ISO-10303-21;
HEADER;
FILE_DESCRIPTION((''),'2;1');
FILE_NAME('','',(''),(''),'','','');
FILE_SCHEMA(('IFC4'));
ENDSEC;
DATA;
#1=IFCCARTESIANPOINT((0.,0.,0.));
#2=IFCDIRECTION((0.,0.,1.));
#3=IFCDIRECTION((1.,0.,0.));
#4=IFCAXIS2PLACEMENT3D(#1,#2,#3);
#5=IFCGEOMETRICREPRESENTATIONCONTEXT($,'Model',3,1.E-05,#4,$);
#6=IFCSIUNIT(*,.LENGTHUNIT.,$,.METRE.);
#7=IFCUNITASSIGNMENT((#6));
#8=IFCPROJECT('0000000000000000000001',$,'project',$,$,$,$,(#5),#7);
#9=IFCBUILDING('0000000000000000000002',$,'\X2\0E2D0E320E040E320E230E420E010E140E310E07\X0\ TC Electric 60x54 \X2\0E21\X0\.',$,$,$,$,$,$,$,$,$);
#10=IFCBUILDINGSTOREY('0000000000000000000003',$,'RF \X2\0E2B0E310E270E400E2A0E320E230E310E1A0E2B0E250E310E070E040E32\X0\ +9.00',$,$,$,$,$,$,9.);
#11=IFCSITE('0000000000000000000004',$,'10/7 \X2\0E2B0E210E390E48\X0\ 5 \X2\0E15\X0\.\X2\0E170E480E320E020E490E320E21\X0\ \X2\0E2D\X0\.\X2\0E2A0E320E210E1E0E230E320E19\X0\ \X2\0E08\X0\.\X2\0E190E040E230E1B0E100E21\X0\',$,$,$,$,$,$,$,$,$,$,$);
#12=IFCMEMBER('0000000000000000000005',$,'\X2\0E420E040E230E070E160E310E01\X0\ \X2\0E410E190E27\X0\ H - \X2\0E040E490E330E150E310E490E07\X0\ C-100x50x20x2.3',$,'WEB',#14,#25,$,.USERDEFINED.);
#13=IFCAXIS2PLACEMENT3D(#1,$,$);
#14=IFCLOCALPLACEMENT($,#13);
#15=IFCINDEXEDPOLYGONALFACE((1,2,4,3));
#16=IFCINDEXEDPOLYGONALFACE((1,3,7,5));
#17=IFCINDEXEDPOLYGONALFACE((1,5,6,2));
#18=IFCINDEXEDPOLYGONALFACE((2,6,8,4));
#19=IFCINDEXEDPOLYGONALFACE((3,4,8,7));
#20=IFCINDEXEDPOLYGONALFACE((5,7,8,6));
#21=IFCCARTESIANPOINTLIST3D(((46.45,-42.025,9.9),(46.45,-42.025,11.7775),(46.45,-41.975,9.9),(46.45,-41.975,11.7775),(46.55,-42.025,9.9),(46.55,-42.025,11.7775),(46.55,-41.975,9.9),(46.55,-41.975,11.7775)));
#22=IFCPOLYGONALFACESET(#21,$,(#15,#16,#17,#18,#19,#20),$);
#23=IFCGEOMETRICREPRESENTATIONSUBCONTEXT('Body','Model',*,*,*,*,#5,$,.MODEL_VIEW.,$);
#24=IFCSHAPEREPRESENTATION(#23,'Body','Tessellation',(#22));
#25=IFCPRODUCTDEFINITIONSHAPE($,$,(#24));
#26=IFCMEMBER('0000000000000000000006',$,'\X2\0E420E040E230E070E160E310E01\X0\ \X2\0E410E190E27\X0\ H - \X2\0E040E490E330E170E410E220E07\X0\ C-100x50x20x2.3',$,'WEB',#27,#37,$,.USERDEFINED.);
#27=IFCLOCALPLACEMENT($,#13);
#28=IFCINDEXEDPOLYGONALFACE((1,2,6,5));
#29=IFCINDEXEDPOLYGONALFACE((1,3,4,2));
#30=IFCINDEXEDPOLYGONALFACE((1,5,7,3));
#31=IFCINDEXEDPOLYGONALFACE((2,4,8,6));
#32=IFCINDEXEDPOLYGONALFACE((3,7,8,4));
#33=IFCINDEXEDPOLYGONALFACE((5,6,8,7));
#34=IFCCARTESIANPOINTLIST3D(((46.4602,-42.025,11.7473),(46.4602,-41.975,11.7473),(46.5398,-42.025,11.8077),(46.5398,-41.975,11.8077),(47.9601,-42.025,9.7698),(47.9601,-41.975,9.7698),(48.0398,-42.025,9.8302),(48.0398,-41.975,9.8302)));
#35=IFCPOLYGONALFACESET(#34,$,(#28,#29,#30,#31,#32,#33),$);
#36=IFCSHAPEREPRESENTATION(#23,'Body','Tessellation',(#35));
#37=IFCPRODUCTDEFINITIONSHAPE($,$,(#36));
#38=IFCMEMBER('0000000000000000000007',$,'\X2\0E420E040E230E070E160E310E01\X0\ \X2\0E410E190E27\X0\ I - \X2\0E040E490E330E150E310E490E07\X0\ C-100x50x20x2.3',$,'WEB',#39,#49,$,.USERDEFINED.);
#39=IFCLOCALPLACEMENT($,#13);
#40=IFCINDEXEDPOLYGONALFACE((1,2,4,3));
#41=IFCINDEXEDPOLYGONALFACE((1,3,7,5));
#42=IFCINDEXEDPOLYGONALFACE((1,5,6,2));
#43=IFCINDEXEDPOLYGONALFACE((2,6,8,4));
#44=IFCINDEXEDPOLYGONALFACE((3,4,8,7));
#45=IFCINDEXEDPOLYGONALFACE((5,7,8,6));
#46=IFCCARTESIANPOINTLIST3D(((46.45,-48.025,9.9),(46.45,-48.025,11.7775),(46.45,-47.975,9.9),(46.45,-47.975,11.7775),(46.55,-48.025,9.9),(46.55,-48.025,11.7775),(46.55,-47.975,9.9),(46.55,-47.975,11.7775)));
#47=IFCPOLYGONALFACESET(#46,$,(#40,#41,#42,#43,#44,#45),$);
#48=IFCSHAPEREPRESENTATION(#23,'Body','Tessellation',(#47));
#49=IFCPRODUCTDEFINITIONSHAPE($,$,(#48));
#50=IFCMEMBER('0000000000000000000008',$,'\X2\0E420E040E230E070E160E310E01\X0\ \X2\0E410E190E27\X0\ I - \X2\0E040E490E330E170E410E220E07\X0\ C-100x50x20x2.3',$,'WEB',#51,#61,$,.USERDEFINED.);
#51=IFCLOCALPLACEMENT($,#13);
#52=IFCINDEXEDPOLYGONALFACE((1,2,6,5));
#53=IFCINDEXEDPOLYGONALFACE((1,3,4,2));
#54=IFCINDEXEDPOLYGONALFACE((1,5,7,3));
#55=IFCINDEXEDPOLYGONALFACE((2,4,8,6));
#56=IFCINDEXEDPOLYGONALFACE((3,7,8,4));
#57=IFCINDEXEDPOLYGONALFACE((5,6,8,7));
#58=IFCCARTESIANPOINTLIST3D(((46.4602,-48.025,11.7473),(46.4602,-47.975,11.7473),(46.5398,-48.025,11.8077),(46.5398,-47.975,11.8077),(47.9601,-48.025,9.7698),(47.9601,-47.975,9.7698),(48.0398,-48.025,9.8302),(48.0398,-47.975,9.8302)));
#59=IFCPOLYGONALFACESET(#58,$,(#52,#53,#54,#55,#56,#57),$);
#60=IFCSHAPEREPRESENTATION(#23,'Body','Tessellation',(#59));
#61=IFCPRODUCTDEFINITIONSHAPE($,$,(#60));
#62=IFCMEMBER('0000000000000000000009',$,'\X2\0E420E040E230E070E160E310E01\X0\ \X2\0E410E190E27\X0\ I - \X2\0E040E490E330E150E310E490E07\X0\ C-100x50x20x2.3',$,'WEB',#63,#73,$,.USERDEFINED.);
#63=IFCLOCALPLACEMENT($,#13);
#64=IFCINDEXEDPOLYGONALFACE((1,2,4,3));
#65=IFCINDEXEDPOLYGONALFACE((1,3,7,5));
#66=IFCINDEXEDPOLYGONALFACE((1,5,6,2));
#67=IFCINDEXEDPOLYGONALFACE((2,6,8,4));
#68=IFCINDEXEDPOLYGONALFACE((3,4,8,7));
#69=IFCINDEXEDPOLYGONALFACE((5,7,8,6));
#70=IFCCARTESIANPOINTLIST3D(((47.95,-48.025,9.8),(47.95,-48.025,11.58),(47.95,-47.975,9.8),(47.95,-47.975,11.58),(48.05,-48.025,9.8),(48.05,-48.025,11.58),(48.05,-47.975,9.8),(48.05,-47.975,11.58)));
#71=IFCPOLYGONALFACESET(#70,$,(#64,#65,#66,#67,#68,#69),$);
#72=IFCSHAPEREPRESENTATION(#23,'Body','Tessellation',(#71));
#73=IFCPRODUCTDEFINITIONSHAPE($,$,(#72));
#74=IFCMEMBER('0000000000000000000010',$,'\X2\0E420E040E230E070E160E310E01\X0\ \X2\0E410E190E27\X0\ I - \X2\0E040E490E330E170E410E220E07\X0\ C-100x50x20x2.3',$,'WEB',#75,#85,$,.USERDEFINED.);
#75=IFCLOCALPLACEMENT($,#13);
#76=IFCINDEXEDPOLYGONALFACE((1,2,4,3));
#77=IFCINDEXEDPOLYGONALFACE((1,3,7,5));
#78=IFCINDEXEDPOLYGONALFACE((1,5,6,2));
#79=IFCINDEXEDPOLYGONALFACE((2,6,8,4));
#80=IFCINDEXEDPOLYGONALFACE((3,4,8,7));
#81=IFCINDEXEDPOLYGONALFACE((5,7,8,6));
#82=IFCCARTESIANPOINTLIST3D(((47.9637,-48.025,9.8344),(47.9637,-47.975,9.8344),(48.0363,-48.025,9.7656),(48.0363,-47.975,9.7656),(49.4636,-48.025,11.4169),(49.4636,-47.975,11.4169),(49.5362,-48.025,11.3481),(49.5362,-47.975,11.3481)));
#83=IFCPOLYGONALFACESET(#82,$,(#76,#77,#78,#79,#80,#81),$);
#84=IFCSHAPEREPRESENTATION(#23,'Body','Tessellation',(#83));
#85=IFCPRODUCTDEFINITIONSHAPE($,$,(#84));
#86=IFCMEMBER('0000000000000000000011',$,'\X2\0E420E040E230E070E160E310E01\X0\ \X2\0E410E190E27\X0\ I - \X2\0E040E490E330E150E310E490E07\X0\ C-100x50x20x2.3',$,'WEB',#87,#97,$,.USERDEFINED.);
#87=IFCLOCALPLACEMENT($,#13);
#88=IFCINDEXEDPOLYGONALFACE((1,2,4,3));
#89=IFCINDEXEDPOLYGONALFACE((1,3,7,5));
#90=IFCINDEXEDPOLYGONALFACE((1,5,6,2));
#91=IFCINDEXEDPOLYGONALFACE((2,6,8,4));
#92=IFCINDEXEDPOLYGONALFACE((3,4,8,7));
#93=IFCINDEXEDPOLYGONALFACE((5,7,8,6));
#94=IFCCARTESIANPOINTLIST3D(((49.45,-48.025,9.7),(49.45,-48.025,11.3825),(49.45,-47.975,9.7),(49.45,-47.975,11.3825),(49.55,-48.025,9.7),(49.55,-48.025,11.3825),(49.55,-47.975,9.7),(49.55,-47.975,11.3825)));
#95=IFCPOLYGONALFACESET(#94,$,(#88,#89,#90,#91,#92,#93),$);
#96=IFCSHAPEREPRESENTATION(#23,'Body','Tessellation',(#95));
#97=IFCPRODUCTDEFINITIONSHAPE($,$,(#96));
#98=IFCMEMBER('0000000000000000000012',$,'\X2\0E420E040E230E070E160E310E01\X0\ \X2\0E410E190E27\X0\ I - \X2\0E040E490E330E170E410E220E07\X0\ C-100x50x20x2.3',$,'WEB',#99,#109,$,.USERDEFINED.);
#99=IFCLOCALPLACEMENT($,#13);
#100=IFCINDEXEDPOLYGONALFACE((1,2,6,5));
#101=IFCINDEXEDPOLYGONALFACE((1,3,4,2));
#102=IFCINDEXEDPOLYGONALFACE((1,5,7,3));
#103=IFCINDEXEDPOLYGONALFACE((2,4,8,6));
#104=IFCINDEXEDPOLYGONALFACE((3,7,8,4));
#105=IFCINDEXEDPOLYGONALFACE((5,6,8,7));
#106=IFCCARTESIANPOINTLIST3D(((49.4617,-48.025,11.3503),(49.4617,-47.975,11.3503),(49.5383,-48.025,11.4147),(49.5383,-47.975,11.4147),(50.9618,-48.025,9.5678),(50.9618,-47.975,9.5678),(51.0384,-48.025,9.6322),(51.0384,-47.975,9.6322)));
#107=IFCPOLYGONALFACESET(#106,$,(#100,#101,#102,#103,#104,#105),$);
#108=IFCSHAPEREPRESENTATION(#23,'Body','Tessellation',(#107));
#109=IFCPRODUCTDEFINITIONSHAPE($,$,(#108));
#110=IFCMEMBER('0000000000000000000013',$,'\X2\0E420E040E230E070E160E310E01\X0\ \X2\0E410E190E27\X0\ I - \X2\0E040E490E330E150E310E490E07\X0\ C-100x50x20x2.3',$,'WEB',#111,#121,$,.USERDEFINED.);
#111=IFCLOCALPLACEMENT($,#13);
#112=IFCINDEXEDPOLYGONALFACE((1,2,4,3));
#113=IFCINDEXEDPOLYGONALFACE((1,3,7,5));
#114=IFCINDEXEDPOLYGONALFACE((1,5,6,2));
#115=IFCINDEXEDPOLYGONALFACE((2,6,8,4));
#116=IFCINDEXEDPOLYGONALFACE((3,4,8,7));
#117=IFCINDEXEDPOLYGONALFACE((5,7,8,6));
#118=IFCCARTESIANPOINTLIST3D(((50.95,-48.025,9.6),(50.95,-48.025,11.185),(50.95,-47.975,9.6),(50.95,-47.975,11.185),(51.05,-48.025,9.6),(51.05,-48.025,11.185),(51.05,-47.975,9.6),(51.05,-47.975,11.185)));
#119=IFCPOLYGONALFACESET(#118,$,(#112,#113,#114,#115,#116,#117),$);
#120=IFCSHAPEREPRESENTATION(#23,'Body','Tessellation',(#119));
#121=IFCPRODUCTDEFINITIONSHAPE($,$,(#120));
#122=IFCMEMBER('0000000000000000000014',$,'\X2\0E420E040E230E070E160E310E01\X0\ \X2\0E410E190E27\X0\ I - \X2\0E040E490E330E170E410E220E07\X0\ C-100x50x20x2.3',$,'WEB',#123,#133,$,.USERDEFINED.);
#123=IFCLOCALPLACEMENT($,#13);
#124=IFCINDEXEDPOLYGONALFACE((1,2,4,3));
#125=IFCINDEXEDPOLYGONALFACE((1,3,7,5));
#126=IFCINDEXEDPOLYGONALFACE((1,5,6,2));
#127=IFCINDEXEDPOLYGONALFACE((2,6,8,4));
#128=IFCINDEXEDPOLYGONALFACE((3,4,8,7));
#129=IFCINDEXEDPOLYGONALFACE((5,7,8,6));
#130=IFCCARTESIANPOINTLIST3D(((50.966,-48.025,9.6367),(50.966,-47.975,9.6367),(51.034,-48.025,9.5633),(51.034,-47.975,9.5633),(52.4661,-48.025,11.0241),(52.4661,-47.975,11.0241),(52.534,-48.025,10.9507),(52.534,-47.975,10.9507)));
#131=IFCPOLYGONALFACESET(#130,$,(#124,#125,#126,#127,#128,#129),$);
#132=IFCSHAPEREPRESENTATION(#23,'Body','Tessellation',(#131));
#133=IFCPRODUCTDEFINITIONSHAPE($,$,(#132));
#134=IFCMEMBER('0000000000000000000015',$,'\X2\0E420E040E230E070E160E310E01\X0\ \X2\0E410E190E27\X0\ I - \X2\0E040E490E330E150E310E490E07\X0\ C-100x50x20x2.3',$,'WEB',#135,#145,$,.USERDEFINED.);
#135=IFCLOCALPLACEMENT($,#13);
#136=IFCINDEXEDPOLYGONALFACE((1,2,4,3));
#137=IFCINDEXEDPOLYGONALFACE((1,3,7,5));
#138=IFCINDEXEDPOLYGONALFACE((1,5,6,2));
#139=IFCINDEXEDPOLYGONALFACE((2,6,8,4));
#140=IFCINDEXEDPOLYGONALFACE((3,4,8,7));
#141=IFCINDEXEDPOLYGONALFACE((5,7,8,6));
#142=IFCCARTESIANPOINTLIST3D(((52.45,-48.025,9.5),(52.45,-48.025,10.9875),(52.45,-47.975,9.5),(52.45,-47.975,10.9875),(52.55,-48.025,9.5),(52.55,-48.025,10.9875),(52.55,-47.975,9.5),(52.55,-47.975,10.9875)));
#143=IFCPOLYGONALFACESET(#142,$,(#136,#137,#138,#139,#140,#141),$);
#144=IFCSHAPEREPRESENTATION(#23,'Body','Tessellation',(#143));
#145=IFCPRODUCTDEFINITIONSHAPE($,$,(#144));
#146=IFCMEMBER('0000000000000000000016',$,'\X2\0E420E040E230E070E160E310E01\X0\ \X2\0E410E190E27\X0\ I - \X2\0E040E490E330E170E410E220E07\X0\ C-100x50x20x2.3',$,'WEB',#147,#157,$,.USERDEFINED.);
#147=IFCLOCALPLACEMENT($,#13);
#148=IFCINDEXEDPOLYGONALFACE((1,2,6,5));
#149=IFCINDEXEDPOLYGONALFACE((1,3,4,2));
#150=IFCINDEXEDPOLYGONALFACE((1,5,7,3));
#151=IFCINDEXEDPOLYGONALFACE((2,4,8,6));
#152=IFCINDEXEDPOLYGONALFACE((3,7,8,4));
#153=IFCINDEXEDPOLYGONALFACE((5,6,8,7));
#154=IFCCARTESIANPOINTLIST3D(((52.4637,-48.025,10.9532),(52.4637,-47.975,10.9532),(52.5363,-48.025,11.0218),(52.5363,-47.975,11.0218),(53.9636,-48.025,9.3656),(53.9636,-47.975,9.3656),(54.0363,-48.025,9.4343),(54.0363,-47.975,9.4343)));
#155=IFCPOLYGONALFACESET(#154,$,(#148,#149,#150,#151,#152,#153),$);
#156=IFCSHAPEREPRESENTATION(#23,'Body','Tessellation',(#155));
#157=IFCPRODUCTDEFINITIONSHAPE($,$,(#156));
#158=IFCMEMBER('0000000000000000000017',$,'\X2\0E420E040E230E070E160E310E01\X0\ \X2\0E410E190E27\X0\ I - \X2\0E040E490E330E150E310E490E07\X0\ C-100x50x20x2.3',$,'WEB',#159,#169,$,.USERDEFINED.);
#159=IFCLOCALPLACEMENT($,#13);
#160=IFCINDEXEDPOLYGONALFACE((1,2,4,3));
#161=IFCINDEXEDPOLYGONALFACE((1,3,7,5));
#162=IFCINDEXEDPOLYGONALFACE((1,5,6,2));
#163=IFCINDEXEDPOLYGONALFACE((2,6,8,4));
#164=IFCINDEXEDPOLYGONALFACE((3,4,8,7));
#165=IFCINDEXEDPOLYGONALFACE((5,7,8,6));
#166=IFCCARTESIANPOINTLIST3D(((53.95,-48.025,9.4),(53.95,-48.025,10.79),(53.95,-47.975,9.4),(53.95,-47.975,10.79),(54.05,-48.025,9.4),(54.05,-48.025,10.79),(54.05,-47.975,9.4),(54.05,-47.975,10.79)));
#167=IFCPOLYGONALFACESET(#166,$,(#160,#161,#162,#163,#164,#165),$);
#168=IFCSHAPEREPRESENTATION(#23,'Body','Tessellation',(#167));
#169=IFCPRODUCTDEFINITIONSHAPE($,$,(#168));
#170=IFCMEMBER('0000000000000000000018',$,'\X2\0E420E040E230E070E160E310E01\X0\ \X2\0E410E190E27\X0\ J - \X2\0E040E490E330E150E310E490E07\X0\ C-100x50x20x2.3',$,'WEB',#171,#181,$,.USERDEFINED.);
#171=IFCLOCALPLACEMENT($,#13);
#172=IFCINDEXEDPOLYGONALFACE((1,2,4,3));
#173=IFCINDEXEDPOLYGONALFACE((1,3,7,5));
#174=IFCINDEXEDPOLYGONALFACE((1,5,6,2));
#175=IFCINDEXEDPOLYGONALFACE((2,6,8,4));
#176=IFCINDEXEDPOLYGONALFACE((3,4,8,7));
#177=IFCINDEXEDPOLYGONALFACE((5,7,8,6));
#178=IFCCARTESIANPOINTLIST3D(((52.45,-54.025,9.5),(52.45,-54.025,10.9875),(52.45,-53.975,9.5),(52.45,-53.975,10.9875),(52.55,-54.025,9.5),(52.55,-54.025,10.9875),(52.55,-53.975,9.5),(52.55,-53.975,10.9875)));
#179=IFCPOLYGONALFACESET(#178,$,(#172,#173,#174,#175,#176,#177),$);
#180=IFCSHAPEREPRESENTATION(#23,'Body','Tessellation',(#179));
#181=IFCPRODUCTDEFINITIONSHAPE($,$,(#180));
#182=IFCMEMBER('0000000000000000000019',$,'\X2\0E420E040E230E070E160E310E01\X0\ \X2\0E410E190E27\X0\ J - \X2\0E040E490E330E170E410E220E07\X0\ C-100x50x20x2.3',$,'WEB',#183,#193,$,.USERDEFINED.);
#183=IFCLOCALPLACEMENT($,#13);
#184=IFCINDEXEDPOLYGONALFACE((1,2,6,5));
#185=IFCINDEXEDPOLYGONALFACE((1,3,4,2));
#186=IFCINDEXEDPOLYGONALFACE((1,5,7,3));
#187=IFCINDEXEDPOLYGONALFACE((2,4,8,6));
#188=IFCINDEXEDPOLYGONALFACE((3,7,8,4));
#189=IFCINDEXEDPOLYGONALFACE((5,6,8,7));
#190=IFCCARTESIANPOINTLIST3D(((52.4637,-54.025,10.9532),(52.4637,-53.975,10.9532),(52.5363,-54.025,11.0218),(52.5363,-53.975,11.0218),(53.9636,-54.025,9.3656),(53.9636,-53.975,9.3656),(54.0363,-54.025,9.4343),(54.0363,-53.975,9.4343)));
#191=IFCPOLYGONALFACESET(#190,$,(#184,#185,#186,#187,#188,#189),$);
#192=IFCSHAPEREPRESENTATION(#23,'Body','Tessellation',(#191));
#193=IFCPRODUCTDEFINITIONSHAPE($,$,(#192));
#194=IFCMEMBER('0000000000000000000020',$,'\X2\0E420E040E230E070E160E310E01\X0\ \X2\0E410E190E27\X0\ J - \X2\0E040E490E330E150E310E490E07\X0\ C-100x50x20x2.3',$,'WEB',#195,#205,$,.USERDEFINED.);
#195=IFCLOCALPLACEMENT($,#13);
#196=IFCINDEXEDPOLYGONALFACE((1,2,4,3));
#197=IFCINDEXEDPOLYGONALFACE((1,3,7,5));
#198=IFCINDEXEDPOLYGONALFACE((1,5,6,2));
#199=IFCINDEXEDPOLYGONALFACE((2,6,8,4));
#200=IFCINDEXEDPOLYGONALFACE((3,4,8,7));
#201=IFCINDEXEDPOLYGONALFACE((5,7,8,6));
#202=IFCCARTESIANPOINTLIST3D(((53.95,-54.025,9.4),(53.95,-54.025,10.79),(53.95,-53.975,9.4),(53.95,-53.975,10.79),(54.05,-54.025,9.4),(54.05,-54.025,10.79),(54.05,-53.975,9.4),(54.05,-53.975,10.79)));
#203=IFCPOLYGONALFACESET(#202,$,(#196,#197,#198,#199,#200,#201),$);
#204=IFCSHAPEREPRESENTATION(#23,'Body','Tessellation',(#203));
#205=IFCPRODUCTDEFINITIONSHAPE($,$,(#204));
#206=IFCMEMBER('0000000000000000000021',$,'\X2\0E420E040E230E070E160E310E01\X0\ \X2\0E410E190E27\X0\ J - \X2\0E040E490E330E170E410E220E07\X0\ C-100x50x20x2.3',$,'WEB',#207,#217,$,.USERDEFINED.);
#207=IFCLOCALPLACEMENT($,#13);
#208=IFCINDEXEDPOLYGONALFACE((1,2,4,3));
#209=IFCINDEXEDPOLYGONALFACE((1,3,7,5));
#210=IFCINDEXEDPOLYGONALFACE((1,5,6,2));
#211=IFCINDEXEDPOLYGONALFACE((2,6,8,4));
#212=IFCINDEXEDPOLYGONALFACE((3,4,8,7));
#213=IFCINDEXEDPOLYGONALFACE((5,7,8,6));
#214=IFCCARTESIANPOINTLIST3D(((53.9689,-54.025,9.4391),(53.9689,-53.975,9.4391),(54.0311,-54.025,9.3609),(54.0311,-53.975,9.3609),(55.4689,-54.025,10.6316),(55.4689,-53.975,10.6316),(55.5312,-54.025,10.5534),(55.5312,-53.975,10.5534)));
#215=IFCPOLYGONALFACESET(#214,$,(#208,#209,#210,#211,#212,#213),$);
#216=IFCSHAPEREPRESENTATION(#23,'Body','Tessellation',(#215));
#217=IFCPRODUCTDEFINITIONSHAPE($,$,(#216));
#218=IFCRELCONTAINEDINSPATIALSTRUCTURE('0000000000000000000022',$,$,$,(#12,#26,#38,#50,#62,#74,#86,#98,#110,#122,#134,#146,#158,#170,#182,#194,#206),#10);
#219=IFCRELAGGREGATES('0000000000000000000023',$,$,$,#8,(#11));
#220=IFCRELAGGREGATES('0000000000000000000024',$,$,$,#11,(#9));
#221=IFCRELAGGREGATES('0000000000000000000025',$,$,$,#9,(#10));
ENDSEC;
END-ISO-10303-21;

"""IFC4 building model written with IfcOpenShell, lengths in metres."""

from ifc_helpers import new_model, si_unit, frame, origin, origin_with_axes, origin_2d, place, context, subcontext, project, spatial, rectangle, extrude, element, save


model = new_model("IFC4")

# Units and contexts
model_context = context("Model", 3, precision=1e-05, world=origin_with_axes())
body_context = subcontext(model_context, "Body", "Model", "MODEL_VIEW")
ifc_project = project(units=[si_unit("LENGTHUNIT", "METRE")], contexts=[model_context])

# Site, building, storey
site = spatial("IfcSite", under=ifc_project, Name="10/7 หมู่ 5 ต.ท่าข้าม อ.สามพราน จ.นครปฐม")
building = spatial("IfcBuilding", under=site, Name="อาคารโกดัง TC Electric 60x54 ม.")
storey = spatial("IfcBuildingStorey", under=building, Name="RF หัวเสารับหลังคา +9.00", Elevation=9.0)

# Members
member_1_placement = place(None, frame((46.5, -42.0, 9.9), z_axis=(0.0, 0.0, 1.0), x_axis=(0.0, 1.0, 0.0)))
element("IfcMember", 1, at=member_1_placement, inside=storey, Name="โครงถัก แนว H - ค้ำตั้ง C-100x50x20x2.3", ObjectType="WEB", PredefinedType="USERDEFINED", context=body_context, shape_type="SweptSolid", body=[
    extrude(rectangle(XDim=0.05, YDim=0.1, at=origin_2d()), origin(), (0.0, 0.0, 1.0), 1.8775),
])
member_2_placement = place(None, frame((46.5, -42.0, 11.7775), z_axis=(0.6043, 0.0, -0.7967), x_axis=(0.0, -1.0, 0.0)))
element("IfcMember", 2, at=member_2_placement, inside=storey, Name="โครงถัก แนว H - ค้ำทแยง C-100x50x20x2.3", ObjectType="WEB", PredefinedType="USERDEFINED", context=body_context, shape_type="SweptSolid", body=[
    extrude(rectangle(XDim=0.05, YDim=0.1, at=origin_2d()), origin(), (0.0, 0.0, 1.0), 2.482),
])
member_3_placement = place(None, frame((46.5, -48.0, 9.9), z_axis=(0.0, 0.0, 1.0), x_axis=(0.0, 1.0, 0.0)))
element("IfcMember", 3, at=member_3_placement, inside=storey, Name="โครงถัก แนว I - ค้ำตั้ง C-100x50x20x2.3", ObjectType="WEB", PredefinedType="USERDEFINED", context=body_context, shape_type="SweptSolid", body=[
    extrude(rectangle(XDim=0.05, YDim=0.1, at=origin_2d()), origin(), (0.0, 0.0, 1.0), 1.8775),
])
member_4_placement = place(None, frame((46.5, -48.0, 11.7775), z_axis=(0.6043, 0.0, -0.7967), x_axis=(0.0, -1.0, 0.0)))
element("IfcMember", 4, at=member_4_placement, inside=storey, Name="โครงถัก แนว I - ค้ำทแยง C-100x50x20x2.3", ObjectType="WEB", PredefinedType="USERDEFINED", context=body_context, shape_type="SweptSolid", body=[
    extrude(rectangle(XDim=0.05, YDim=0.1, at=origin_2d()), origin(), (0.0, 0.0, 1.0), 2.482),
])
member_5_placement = place(None, frame((48.0, -48.0, 9.8), z_axis=(0.0, 0.0, 1.0), x_axis=(0.0, 1.0, 0.0)))
element("IfcMember", 5, at=member_5_placement, inside=storey, Name="โครงถัก แนว I - ค้ำตั้ง C-100x50x20x2.3", ObjectType="WEB", PredefinedType="USERDEFINED", context=body_context, shape_type="SweptSolid", body=[
    extrude(rectangle(XDim=0.05, YDim=0.1, at=origin_2d()), origin(), (0.0, 0.0, 1.0), 1.78),
])
member_6_placement = place(None, frame((48.0, -48.0, 9.8), z_axis=(0.6879, 0.0, 0.7258), x_axis=(0.0, -1.0, 0.0)))
element("IfcMember", 6, at=member_6_placement, inside=storey, Name="โครงถัก แนว I - ค้ำทแยง C-100x50x20x2.3", ObjectType="WEB", PredefinedType="USERDEFINED", context=body_context, shape_type="SweptSolid", body=[
    extrude(rectangle(XDim=0.05, YDim=0.1, at=origin_2d()), origin(), (0.0, 0.0, 1.0), 2.1804),
])
member_7_placement = place(None, frame((49.5, -48.0, 9.7), z_axis=(0.0, 0.0, 1.0), x_axis=(0.0, 1.0, 0.0)))
element("IfcMember", 7, at=member_7_placement, inside=storey, Name="โครงถัก แนว I - ค้ำตั้ง C-100x50x20x2.3", ObjectType="WEB", PredefinedType="USERDEFINED", context=body_context, shape_type="SweptSolid", body=[
    extrude(rectangle(XDim=0.05, YDim=0.1, at=origin_2d()), origin(), (0.0, 0.0, 1.0), 1.6825),
])
member_8_placement = place(None, frame((49.5, -48.0, 11.3825), z_axis=(0.6439, 0.0, -0.7651), x_axis=(0.0, -1.0, 0.0)))
element("IfcMember", 8, at=member_8_placement, inside=storey, Name="โครงถัก แนว I - ค้ำทแยง C-100x50x20x2.3", ObjectType="WEB", PredefinedType="USERDEFINED", context=body_context, shape_type="SweptSolid", body=[
    extrude(rectangle(XDim=0.05, YDim=0.1, at=origin_2d()), origin(), (0.0, 0.0, 1.0), 2.3297),
])
member_9_placement = place(None, frame((51.0, -48.0, 9.6), z_axis=(0.0, 0.0, 1.0), x_axis=(0.0, 1.0, 0.0)))
element("IfcMember", 9, at=member_9_placement, inside=storey, Name="โครงถัก แนว I - ค้ำตั้ง C-100x50x20x2.3", ObjectType="WEB", PredefinedType="USERDEFINED", context=body_context, shape_type="SweptSolid", body=[
    extrude(rectangle(XDim=0.05, YDim=0.1, at=origin_2d()), origin(), (0.0, 0.0, 1.0), 1.585),
])
member_10_placement = place(None, frame((51.0, -48.0, 9.6), z_axis=(0.7341, 0.0, 0.679), x_axis=(0.0, -1.0, 0.0)))
element("IfcMember", 10, at=member_10_placement, inside=storey, Name="โครงถัก แนว I - ค้ำทแยง C-100x50x20x2.3", ObjectType="WEB", PredefinedType="USERDEFINED", context=body_context, shape_type="SweptSolid", body=[
    extrude(rectangle(XDim=0.05, YDim=0.1, at=origin_2d()), origin(), (0.0, 0.0, 1.0), 2.0433),
])
member_11_placement = place(None, frame((52.5, -48.0, 9.5), z_axis=(0.0, 0.0, 1.0), x_axis=(0.0, 1.0, 0.0)))
element("IfcMember", 11, at=member_11_placement, inside=storey, Name="โครงถัก แนว I - ค้ำตั้ง C-100x50x20x2.3", ObjectType="WEB", PredefinedType="USERDEFINED", context=body_context, shape_type="SweptSolid", body=[
    extrude(rectangle(XDim=0.05, YDim=0.1, at=origin_2d()), origin(), (0.0, 0.0, 1.0), 1.4875),
])
member_12_placement = place(None, frame((52.5, -48.0, 10.9875), z_axis=(0.6868, 0.0, -0.7269), x_axis=(0.0, -1.0, 0.0)))
element("IfcMember", 12, at=member_12_placement, inside=storey, Name="โครงถัก แนว I - ค้ำทแยง C-100x50x20x2.3", ObjectType="WEB", PredefinedType="USERDEFINED", context=body_context, shape_type="SweptSolid", body=[
    extrude(rectangle(XDim=0.05, YDim=0.1, at=origin_2d()), origin(), (0.0, 0.0, 1.0), 2.1841),
])
member_13_placement = place(None, frame((54.0, -48.0, 9.4), z_axis=(0.0, 0.0, 1.0), x_axis=(0.0, 1.0, 0.0)))
element("IfcMember", 13, at=member_13_placement, inside=storey, Name="โครงถัก แนว I - ค้ำตั้ง C-100x50x20x2.3", ObjectType="WEB", PredefinedType="USERDEFINED", context=body_context, shape_type="SweptSolid", body=[
    extrude(rectangle(XDim=0.05, YDim=0.1, at=origin_2d()), origin(), (0.0, 0.0, 1.0), 1.39),
])
member_14_placement = place(None, frame((52.5, -54.0, 9.5), z_axis=(0.0, 0.0, 1.0), x_axis=(0.0, 1.0, 0.0)))
element("IfcMember", 14, at=member_14_placement, inside=storey, Name="โครงถัก แนว J - ค้ำตั้ง C-100x50x20x2.3", ObjectType="WEB", PredefinedType="USERDEFINED", context=body_context, shape_type="SweptSolid", body=[
    extrude(rectangle(XDim=0.05, YDim=0.1, at=origin_2d()), origin(), (0.0, 0.0, 1.0), 1.4875),
])
member_15_placement = place(None, frame((52.5, -54.0, 10.9875), z_axis=(0.6868, 0.0, -0.7269), x_axis=(0.0, -1.0, 0.0)))
element("IfcMember", 15, at=member_15_placement, inside=storey, Name="โครงถัก แนว J - ค้ำทแยง C-100x50x20x2.3", ObjectType="WEB", PredefinedType="USERDEFINED", context=body_context, shape_type="SweptSolid", body=[
    extrude(rectangle(XDim=0.05, YDim=0.1, at=origin_2d()), origin(), (0.0, 0.0, 1.0), 2.1841),
])
member_16_placement = place(None, frame((54.0, -54.0, 9.4), z_axis=(0.0, 0.0, 1.0), x_axis=(0.0, 1.0, 0.0)))
element("IfcMember", 16, at=member_16_placement, inside=storey, Name="โครงถัก แนว J - ค้ำตั้ง C-100x50x20x2.3", ObjectType="WEB", PredefinedType="USERDEFINED", context=body_context, shape_type="SweptSolid", body=[
    extrude(rectangle(XDim=0.05, YDim=0.1, at=origin_2d()), origin(), (0.0, 0.0, 1.0), 1.39),
])
member_17_placement = place(None, frame((54.0, -54.0, 9.4), z_axis=(0.7828, 0.0, 0.6223), x_axis=(0.0, -1.0, 0.0)))
element("IfcMember", 17, at=member_17_placement, inside=storey, Name="โครงถัก แนว J - ค้ำทแยง C-100x50x20x2.3", ObjectType="WEB", PredefinedType="USERDEFINED", context=body_context, shape_type="SweptSolid", body=[
    extrude(rectangle(XDim=0.05, YDim=0.1, at=origin_2d()), origin(), (0.0, 0.0, 1.0), 1.9163),
])

save(model, "model.ifc")
